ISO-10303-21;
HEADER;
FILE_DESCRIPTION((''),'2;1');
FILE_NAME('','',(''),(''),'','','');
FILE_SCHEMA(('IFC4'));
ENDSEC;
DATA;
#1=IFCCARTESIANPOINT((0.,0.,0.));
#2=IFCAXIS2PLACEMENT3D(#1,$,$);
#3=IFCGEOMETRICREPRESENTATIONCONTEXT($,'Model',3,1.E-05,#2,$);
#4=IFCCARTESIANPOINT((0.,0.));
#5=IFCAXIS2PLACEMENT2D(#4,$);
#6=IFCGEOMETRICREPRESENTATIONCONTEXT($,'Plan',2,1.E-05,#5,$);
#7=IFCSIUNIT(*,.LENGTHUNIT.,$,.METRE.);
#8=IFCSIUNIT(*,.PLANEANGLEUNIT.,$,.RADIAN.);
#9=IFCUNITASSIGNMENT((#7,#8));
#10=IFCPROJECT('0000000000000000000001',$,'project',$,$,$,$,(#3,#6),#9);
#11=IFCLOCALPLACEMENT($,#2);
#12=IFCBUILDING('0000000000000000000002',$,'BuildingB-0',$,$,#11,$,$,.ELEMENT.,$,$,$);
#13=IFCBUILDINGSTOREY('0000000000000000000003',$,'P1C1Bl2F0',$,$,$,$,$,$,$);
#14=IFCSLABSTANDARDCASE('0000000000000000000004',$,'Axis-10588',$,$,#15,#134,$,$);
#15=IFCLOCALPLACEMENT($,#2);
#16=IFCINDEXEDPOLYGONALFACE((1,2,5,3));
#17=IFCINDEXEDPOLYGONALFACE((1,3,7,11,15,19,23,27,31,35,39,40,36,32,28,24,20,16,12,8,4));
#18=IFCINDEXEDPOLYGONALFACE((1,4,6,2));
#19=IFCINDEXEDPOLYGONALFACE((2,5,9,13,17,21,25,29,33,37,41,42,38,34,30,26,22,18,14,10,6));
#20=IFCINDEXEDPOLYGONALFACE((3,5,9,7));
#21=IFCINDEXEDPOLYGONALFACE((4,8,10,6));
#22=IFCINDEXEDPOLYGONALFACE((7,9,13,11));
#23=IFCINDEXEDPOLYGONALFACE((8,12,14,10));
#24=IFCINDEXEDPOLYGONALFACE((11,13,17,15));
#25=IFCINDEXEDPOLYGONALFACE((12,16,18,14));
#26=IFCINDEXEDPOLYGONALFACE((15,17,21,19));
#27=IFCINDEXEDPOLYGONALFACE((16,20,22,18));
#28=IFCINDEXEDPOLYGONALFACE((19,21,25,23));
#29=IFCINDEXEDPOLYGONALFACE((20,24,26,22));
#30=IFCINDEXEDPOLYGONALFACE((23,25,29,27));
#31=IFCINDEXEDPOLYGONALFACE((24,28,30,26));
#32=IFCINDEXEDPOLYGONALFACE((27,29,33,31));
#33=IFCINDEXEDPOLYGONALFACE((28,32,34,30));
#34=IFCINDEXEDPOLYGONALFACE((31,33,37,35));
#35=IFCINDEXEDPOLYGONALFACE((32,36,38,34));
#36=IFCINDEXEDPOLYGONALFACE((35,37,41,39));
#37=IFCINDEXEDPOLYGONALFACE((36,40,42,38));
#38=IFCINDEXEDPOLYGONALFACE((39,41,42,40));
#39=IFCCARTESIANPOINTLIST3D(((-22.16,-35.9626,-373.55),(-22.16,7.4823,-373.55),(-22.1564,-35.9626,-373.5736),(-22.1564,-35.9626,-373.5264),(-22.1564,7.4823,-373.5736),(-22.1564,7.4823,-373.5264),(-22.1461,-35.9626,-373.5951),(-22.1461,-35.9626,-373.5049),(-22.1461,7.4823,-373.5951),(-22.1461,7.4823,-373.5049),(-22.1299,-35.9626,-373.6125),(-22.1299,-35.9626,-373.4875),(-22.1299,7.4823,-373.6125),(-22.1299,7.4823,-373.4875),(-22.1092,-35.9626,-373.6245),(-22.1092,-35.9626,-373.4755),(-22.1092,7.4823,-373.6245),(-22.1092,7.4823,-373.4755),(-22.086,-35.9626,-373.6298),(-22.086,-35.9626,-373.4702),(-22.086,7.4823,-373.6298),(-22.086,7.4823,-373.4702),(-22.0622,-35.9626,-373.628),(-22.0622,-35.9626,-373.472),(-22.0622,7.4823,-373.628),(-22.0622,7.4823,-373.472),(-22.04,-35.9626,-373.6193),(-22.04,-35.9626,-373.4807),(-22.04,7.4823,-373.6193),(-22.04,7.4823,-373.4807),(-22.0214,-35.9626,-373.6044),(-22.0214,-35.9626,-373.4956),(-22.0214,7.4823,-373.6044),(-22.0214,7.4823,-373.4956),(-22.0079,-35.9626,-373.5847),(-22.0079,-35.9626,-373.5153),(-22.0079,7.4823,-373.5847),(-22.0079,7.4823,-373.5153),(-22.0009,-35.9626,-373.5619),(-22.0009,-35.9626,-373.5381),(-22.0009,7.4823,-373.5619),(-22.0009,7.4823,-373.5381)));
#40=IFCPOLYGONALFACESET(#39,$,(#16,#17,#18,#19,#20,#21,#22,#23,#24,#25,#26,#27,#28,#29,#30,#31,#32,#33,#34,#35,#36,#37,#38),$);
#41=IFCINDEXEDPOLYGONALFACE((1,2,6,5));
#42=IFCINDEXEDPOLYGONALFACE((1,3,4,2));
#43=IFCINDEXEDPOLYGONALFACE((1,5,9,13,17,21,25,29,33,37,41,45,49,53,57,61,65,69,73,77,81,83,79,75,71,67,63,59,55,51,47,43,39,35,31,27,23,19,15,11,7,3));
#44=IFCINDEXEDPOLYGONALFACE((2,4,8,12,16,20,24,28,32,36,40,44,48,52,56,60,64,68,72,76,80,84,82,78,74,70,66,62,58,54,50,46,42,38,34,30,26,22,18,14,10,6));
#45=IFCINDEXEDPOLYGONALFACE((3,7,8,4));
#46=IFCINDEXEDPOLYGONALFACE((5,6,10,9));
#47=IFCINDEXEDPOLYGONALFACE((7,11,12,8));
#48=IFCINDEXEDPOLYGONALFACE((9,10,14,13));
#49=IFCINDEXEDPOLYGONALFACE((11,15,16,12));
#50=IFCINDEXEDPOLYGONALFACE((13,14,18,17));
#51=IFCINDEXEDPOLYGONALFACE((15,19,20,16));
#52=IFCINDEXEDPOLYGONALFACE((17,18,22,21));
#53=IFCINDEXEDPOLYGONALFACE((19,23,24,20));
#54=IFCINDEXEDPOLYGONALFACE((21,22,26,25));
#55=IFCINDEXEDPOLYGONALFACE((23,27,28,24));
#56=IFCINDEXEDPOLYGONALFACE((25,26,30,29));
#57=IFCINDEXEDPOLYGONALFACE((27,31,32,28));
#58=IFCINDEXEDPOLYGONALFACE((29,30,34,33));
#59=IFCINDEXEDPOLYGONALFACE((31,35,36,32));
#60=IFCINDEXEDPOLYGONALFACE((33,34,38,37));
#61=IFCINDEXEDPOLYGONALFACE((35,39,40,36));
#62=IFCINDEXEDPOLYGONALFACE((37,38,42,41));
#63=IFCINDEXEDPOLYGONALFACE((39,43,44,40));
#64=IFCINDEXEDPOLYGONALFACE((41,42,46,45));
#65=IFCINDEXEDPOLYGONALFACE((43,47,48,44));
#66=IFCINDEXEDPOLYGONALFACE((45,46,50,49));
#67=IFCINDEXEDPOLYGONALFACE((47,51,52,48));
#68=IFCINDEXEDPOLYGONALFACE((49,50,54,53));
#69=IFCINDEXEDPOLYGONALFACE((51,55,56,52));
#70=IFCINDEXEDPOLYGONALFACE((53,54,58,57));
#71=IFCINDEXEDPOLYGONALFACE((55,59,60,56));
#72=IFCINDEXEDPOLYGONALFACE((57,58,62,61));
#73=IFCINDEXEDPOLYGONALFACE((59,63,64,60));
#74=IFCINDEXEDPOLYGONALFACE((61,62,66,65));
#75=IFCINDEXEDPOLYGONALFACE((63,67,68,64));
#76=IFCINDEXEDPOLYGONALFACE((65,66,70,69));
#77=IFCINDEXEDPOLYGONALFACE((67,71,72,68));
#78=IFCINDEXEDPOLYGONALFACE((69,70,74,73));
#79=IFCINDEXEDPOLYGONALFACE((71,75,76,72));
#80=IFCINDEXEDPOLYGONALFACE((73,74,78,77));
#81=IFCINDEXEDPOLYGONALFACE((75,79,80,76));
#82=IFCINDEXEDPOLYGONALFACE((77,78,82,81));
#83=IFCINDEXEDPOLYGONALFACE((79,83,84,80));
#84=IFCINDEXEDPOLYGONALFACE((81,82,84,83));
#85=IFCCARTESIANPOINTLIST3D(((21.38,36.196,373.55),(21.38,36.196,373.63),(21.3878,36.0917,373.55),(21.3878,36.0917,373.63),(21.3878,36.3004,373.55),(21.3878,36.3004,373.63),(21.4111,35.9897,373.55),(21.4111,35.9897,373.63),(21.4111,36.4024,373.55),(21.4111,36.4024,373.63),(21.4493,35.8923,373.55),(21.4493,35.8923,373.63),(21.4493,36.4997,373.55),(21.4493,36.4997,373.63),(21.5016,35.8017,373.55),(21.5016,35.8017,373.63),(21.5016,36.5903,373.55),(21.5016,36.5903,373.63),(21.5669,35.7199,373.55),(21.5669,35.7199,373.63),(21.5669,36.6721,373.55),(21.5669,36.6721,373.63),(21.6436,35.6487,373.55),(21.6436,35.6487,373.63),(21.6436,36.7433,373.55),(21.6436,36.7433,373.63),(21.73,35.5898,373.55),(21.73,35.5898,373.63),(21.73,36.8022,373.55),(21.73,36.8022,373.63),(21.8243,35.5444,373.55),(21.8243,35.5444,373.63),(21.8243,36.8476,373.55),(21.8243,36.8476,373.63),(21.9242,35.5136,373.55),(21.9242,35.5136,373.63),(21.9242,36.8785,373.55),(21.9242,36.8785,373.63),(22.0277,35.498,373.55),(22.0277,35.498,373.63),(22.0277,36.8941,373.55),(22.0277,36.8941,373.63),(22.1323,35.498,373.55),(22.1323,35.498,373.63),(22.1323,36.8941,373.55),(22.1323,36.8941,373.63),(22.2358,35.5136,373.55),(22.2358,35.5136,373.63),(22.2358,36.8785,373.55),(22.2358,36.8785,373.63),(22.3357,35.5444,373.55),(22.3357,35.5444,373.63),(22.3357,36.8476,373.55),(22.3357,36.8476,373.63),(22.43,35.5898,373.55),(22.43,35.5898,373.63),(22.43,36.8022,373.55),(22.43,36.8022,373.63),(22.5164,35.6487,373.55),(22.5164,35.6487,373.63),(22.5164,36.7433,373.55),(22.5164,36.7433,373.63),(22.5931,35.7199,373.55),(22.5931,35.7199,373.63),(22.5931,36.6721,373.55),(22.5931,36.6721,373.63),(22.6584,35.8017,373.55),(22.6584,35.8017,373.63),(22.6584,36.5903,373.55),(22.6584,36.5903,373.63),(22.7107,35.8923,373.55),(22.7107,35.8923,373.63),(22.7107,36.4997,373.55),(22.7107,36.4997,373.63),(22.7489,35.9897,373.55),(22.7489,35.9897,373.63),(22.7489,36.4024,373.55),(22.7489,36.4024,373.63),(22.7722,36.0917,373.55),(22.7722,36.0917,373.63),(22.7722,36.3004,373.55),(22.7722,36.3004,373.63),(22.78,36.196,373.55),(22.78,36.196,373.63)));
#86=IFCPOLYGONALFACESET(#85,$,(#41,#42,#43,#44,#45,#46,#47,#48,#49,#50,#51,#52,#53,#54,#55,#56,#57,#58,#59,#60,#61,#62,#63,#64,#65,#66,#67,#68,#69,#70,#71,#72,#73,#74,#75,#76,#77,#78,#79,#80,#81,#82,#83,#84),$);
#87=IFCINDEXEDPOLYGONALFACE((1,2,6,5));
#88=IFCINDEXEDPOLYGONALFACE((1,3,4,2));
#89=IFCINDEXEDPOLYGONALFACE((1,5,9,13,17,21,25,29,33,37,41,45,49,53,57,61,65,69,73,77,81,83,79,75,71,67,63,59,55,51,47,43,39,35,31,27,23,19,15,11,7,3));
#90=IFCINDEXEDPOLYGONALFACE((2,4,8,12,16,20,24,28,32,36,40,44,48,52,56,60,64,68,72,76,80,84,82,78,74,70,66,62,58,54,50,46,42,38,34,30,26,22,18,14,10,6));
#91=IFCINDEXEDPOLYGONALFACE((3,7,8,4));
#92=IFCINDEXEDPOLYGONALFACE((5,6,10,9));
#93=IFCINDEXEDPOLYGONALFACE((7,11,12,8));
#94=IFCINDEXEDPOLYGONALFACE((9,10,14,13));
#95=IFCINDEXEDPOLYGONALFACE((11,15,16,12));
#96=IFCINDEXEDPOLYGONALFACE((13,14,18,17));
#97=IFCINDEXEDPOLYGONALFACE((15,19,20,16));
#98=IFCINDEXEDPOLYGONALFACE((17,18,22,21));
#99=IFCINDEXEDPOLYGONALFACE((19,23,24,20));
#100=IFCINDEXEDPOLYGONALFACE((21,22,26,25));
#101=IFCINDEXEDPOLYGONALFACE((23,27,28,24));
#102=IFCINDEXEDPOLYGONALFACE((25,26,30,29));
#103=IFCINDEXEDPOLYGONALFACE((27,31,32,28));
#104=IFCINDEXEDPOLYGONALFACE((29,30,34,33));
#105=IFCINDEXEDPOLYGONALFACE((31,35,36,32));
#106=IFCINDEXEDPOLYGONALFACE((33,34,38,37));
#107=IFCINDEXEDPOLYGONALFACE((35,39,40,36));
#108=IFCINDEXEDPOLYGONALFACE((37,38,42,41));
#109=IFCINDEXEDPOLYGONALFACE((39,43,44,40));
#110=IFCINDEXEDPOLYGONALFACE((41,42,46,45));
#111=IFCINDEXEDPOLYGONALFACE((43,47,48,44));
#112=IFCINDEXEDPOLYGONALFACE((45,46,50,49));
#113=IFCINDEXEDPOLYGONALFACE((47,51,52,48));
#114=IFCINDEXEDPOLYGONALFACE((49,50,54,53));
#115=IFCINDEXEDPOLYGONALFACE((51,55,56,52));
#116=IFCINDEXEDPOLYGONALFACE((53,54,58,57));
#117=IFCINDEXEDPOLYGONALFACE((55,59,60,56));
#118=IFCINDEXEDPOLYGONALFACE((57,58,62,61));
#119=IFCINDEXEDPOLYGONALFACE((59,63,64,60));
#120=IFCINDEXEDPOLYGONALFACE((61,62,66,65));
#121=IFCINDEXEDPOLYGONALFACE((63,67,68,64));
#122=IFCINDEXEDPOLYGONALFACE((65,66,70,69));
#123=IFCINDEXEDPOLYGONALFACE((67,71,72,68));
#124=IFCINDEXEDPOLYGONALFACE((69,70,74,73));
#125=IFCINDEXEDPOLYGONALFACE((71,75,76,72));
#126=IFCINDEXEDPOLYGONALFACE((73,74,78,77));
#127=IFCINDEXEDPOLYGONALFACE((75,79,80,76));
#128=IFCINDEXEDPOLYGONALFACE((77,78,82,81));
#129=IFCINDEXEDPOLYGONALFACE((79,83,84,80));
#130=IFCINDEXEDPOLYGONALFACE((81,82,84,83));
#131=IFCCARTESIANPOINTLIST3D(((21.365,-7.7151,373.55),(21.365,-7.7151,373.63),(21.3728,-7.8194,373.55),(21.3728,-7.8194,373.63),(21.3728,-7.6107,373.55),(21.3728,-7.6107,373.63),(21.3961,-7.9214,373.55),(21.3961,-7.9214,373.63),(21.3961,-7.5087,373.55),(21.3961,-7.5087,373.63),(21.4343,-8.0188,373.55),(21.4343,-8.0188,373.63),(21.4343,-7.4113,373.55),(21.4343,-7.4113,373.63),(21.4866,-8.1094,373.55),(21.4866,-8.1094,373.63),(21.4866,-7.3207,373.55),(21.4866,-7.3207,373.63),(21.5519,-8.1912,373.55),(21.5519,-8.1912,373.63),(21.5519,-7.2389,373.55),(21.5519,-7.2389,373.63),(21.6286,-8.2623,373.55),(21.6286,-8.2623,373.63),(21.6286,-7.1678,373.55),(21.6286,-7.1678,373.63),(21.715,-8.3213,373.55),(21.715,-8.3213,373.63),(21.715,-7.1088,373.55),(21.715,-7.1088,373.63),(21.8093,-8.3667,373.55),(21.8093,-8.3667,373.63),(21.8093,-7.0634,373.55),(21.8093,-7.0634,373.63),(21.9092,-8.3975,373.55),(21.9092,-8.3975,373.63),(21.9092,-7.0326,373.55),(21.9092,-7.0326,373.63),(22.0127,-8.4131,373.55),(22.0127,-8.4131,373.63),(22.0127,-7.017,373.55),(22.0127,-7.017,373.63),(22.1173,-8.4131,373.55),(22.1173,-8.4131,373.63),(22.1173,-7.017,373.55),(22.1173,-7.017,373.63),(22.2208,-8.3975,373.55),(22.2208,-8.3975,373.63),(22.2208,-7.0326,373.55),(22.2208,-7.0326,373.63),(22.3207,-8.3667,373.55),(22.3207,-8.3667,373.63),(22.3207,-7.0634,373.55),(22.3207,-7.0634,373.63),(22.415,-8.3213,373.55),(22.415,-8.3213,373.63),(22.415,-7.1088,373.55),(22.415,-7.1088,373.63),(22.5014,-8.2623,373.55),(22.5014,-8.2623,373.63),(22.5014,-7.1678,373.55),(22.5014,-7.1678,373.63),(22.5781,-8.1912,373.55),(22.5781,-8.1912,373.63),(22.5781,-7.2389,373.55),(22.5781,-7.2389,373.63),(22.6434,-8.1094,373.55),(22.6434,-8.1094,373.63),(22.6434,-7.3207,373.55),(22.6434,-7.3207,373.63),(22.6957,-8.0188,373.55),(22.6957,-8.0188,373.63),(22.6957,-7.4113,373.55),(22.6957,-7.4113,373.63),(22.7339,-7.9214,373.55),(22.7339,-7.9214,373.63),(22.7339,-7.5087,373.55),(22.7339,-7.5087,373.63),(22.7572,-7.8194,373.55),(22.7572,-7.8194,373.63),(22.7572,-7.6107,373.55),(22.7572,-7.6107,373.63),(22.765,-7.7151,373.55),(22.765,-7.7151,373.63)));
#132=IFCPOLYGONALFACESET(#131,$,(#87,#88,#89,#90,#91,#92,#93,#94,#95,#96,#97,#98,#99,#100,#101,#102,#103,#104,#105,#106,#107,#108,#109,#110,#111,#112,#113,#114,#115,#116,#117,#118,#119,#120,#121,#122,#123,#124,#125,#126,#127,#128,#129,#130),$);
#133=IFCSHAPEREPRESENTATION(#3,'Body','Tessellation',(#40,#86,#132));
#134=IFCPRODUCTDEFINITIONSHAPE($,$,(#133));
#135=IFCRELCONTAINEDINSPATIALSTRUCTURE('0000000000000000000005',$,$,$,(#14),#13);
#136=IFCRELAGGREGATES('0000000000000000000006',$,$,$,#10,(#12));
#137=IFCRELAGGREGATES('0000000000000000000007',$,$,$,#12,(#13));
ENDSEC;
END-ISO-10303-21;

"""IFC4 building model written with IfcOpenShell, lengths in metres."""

from ifc_helpers import new_model, entity, si_unit, frame, origin, origin_2d, place, context, project, spatial, circle, extrude, element, save


model = new_model("IFC4")

# Units and contexts
model_context = context("Model", 3, precision=1e-05, world=origin())
plan_context = context("Plan", 2, precision=1e-05, world=origin_2d())
ifc_project = project(units=[si_unit("LENGTHUNIT", "METRE"), si_unit("PLANEANGLEUNIT", "RADIAN")], contexts=[model_context, plan_context])

# Building, storey
building_placement = place(None, origin())
building = spatial("IfcBuilding", under=ifc_project, at=building_placement, Name="BuildingB-0", CompositionType="ELEMENT")
storey = spatial("IfcBuildingStorey", under=building, Name="P1C1Bl2F0")

# Slab
element("IfcSlabStandardCase", 1, inside=storey, Name="Axis-10588", context=model_context, shape_type="AdvancedSweptSolid", body=[
    entity("IfcSurfaceCurveSweptAreaSolid", entity("IfcCircleProfileDef", "AREA", None, None, 0.08), None, entity("IfcPolyline", [entity("IfcCartesianPoint", [22.08, 35.9626, 373.55]), entity("IfcCartesianPoint", [22.08, -7.4823, 373.55])]), None, None, entity("IfcPlane", entity("IfcAxis2Placement3D", entity("IfcCartesianPoint", [22.08, 35.9626, 373.55]), entity("IfcDirection", [0.0, 0.0, 1.0]), entity("IfcDirection", [1.0, 0.0, 0.0])))),
    extrude(circle(Radius=0.7), frame((22.08, 36.196, 373.55)), (0.0, 0.0, 1.0), 0.08),
    extrude(circle(Radius=0.7), frame((22.065, -7.7151, 373.55)), (0.0, 0.0, 1.0), 0.08),
])

save(model, "model.ifc")
